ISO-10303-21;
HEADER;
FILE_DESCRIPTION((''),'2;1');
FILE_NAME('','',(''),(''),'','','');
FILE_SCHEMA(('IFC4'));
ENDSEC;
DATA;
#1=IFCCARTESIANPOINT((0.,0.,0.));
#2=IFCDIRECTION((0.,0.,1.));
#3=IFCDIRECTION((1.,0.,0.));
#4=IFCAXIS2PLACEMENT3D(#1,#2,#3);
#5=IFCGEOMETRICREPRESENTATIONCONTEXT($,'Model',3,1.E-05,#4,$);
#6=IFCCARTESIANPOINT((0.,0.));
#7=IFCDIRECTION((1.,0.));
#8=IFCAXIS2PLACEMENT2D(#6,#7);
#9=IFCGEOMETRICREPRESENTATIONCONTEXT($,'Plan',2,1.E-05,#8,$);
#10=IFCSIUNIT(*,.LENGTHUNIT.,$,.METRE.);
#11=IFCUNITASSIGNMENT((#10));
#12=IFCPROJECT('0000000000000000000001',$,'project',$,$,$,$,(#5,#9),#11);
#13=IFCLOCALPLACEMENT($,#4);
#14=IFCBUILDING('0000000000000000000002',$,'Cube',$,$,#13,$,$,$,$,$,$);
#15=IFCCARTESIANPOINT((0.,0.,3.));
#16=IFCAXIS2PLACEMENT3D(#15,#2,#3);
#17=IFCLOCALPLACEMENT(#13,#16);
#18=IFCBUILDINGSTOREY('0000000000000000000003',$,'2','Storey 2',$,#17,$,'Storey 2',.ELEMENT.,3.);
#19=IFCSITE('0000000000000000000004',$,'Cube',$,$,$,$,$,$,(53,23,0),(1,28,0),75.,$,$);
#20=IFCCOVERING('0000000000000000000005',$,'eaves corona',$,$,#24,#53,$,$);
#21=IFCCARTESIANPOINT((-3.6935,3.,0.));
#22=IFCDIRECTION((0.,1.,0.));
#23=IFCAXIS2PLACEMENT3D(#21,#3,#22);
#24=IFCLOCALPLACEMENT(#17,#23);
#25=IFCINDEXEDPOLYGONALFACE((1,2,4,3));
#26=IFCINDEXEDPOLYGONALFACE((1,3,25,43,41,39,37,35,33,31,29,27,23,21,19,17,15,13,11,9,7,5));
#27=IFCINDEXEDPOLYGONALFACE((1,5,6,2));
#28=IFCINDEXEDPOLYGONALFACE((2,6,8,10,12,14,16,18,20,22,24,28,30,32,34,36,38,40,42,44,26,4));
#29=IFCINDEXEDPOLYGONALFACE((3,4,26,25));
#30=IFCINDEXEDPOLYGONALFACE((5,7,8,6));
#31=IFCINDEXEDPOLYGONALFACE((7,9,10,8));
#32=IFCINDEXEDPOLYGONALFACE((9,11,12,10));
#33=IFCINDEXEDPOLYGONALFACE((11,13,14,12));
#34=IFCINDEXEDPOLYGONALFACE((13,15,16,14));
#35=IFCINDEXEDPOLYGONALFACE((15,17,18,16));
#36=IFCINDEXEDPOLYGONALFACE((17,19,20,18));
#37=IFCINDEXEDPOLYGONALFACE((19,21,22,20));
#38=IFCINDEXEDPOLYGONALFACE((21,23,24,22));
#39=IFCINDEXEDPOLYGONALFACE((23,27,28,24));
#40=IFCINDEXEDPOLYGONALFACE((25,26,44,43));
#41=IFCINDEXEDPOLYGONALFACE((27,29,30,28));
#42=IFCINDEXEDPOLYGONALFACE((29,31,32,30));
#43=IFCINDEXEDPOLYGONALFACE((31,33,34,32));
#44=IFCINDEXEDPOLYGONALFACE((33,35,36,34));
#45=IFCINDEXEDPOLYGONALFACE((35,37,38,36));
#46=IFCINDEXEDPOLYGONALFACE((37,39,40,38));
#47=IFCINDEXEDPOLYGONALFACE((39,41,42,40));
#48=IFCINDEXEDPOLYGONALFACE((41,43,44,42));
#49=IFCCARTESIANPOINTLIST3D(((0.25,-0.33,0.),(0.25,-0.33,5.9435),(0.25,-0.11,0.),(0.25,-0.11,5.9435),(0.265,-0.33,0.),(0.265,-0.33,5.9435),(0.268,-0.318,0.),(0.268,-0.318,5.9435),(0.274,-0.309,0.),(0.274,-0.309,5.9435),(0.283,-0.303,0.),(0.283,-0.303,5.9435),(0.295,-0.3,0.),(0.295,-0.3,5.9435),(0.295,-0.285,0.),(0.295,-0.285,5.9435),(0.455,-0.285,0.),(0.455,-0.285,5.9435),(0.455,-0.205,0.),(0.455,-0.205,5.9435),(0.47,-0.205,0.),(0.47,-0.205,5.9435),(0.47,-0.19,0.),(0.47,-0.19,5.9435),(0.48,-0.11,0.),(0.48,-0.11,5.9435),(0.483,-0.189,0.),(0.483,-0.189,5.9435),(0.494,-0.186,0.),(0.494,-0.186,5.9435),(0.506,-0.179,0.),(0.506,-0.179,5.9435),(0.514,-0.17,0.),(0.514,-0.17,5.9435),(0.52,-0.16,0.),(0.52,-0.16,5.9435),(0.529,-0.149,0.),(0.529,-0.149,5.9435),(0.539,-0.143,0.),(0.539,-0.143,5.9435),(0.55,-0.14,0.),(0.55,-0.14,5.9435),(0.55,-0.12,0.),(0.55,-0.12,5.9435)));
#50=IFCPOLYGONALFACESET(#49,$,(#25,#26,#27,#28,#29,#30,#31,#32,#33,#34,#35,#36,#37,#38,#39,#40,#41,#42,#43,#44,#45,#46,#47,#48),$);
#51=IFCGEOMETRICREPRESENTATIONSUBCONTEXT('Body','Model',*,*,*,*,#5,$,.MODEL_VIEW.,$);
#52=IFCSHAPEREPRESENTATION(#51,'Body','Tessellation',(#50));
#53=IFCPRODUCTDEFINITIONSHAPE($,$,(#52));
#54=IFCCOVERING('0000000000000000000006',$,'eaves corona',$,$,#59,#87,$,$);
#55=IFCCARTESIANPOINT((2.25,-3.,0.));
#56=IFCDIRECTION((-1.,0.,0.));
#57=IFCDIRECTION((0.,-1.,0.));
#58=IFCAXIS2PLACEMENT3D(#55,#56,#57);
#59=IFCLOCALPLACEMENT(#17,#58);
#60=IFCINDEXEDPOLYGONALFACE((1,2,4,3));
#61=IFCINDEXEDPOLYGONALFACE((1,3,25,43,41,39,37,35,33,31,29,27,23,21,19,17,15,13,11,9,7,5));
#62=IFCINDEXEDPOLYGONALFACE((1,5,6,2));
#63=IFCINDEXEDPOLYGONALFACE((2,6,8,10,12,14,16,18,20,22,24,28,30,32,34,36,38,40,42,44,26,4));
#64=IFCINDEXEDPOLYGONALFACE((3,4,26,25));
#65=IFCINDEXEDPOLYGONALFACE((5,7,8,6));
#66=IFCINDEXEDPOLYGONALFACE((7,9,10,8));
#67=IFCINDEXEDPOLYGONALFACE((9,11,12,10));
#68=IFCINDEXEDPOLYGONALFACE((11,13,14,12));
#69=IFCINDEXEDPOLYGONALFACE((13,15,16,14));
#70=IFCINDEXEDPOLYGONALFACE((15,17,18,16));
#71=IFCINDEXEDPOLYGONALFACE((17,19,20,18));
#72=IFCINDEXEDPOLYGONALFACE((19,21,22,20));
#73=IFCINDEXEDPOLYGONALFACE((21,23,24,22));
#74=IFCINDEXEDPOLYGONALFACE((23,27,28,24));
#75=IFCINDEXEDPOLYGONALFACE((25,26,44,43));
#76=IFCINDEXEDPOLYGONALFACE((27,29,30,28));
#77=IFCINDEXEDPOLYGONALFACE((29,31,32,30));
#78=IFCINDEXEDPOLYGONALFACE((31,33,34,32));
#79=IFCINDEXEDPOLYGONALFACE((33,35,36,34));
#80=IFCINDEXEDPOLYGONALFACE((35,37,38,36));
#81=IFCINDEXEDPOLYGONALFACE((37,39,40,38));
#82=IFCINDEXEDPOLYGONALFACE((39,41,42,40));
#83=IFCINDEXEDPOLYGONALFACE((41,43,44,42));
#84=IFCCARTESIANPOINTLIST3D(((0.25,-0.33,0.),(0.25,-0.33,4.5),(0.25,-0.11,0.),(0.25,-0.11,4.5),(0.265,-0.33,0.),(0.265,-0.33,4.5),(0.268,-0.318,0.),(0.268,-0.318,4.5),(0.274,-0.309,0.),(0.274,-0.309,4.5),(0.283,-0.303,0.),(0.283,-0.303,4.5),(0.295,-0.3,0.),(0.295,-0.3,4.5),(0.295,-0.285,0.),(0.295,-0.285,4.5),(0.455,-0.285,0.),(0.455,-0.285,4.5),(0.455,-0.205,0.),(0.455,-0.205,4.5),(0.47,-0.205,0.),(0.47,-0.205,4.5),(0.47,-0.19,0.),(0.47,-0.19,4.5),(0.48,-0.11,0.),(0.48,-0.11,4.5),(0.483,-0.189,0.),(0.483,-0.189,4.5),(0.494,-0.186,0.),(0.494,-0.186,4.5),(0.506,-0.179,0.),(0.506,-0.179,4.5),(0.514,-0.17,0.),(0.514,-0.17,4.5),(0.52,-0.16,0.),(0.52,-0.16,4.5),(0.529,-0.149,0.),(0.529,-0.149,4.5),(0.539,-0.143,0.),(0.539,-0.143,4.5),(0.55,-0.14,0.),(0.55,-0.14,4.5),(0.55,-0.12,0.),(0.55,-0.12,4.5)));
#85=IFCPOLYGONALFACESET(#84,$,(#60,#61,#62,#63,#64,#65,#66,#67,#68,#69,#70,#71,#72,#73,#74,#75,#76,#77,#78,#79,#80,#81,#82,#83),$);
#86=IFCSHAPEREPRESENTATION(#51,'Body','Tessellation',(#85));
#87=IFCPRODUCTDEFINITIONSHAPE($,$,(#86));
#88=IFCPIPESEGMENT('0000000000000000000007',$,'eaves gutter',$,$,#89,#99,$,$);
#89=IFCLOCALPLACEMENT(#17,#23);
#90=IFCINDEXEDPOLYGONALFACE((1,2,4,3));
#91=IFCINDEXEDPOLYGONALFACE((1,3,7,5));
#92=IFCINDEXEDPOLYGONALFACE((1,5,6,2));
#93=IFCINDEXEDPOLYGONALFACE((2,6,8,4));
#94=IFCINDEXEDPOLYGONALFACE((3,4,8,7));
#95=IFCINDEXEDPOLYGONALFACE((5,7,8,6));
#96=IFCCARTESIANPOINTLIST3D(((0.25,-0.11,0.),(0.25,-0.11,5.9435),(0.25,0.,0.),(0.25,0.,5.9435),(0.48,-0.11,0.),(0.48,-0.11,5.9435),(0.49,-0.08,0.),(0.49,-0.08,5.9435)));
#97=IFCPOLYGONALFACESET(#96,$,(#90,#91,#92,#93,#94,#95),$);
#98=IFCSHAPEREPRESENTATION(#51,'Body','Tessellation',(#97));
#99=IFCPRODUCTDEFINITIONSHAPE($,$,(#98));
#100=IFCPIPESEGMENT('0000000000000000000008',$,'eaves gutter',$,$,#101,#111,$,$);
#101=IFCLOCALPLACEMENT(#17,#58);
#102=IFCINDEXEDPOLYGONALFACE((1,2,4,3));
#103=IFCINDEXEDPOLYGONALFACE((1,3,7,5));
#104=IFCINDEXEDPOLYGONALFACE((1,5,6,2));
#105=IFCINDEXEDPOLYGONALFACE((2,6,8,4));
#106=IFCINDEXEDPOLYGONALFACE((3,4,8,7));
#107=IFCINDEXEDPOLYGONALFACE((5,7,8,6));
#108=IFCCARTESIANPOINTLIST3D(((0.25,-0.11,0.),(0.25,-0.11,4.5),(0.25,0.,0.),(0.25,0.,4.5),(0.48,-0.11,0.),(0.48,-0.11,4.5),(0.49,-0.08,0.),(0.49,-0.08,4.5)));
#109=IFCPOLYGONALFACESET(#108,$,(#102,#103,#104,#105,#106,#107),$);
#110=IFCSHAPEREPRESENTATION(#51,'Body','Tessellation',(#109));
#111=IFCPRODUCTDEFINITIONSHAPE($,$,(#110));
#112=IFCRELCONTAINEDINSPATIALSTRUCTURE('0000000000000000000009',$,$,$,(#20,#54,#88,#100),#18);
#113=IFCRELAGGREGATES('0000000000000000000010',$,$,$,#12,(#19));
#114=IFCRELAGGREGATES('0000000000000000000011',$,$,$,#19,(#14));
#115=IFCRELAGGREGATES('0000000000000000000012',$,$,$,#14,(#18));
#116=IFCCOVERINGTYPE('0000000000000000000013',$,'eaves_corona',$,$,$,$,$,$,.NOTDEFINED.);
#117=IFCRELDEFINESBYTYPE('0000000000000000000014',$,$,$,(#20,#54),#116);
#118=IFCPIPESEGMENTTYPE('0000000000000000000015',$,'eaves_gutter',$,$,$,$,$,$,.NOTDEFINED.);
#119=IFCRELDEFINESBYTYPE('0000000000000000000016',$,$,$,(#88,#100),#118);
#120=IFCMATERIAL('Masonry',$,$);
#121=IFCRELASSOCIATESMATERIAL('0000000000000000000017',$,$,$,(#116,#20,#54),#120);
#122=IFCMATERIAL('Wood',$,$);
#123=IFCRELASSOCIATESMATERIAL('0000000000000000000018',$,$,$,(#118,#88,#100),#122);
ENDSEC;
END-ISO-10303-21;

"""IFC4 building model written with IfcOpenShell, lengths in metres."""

from ifc_helpers import new_model, si_unit, frame, origin_with_axes, origin_2d_with_axis, place, context, subcontext, project, spatial, polyline, outline, extrude, material, material_profile, profile_set, profile_usage, type_object, element, save


model = new_model("IFC4")

# Units and contexts
model_context = context("Model", 3, precision=1e-05, world=origin_with_axes())
plan_context = context("Plan", 2, precision=1e-05, world=origin_2d_with_axis())
body_context = subcontext(model_context, "Body", "Model", "MODEL_VIEW")
ifc_project = project(units=[si_unit("LENGTHUNIT", "METRE")], contexts=[model_context, plan_context])

# Site, building, storey
site = spatial("IfcSite", under=ifc_project, Name="Cube", RefLatitude=(53, 23, 0), RefLongitude=(1, 28, 0), RefElevation=75.0)
building_placement = place(None, origin_with_axes())
building = spatial("IfcBuilding", under=site, at=building_placement, Name="Cube")
storey_placement = place(building_placement, frame((0.0, 0.0, 3.0), z_axis=(0.0, 0.0, 1.0), x_axis=(1.0, 0.0, 0.0)))
storey = spatial("IfcBuildingStorey", under=building, at=storey_placement, Name="2", Description="Storey 2", LongName="Storey 2", CompositionType="ELEMENT", Elevation=3.0)

# Coverings
ifc_material_1 = material(Name="Masonry")
ifc_material_profile_1 = material_profile(ifc_material_1, outline(polyline([(0.25, -0.11), (0.25, -0.33), (0.265, -0.33), (0.268, -0.318), (0.274, -0.309), (0.283, -0.303), (0.295, -0.3), (0.295, -0.285), (0.455, -0.285), (0.455, -0.205), (0.47, -0.205), (0.47, -0.19), (0.483, -0.189), (0.494, -0.186), (0.506, -0.179), (0.514, -0.17), (0.52, -0.16), (0.529, -0.149), (0.539, -0.143), (0.55, -0.14), (0.55, -0.12), (0.48, -0.11), (0.25, -0.11)])))
ifc_profile_set_1 = profile_set([ifc_material_profile_1])
ifc_profile_usage_1 = profile_usage(ifc_profile_set_1)
covering_type_1 = type_object("IfcCoveringType", Name="eaves_corona", PredefinedType="NOTDEFINED", material=ifc_profile_set_1)
covering_1_placement = place(storey_placement, frame((-3.6935, 3.0, 0.0), z_axis=(1.0, 0.0, 0.0), x_axis=(0.0, 1.0, 0.0)))
element("IfcCovering", 1, at=covering_1_placement, inside=storey, type_object=covering_type_1, material=ifc_profile_usage_1, Name="eaves corona", context=body_context, shape_type="SweptSolid", body=[
    extrude(outline(polyline([(0.25, -0.11), (0.25, -0.33), (0.265, -0.33), (0.268, -0.318), (0.274, -0.309), (0.283, -0.303), (0.295, -0.3), (0.295, -0.285), (0.455, -0.285), (0.455, -0.205), (0.47, -0.205), (0.47, -0.19), (0.483, -0.189), (0.494, -0.186), (0.506, -0.179), (0.514, -0.17), (0.52, -0.16), (0.529, -0.149), (0.539, -0.143), (0.55, -0.14), (0.55, -0.12), (0.48, -0.11), (0.25, -0.11)])), origin_with_axes(), (0.0, 0.0, 1.0), 5.9435),
])
ifc_profile_usage_2 = profile_usage(ifc_profile_set_1)
covering_2_placement = place(storey_placement, frame((2.25, -3.0, 0.0), z_axis=(-1.0, 0.0, 0.0), x_axis=(0.0, -1.0, 0.0)))
element("IfcCovering", 2, at=covering_2_placement, inside=storey, type_object=covering_type_1, material=ifc_profile_usage_2, Name="eaves corona", context=body_context, shape_type="SweptSolid", body=[
    extrude(outline(polyline([(0.25, -0.11), (0.25, -0.33), (0.265, -0.33), (0.268, -0.318), (0.274, -0.309), (0.283, -0.303), (0.295, -0.3), (0.295, -0.285), (0.455, -0.285), (0.455, -0.205), (0.47, -0.205), (0.47, -0.19), (0.483, -0.189), (0.494, -0.186), (0.506, -0.179), (0.514, -0.17), (0.52, -0.16), (0.529, -0.149), (0.539, -0.143), (0.55, -0.14), (0.55, -0.12), (0.48, -0.11), (0.25, -0.11)])), origin_with_axes(), (0.0, 0.0, 1.0), 4.5),
])

# Pipe segments
ifc_material_2 = material(Name="Wood")
ifc_material_profile_2 = material_profile(ifc_material_2, outline(polyline([(0.25, -0.11), (0.48, -0.11), (0.49, -0.08), (0.25, 0.0), (0.25, -0.11)])))
ifc_profile_set_2 = profile_set([ifc_material_profile_2])
ifc_profile_usage_3 = profile_usage(ifc_profile_set_2)
pipe_segment_type = type_object("IfcPipeSegmentType", Name="eaves_gutter", PredefinedType="NOTDEFINED", material=ifc_profile_set_2)
pipe_segment_1_placement = place(storey_placement, frame((-3.6935, 3.0, 0.0), z_axis=(1.0, 0.0, 0.0), x_axis=(0.0, 1.0, 0.0)))
element("IfcPipeSegment", 3, at=pipe_segment_1_placement, inside=storey, type_object=pipe_segment_type, material=ifc_profile_usage_3, Name="eaves gutter", context=body_context, shape_type="SweptSolid", body=[
    extrude(outline(polyline([(0.25, -0.11), (0.48, -0.11), (0.49, -0.08), (0.25, 0.0), (0.25, -0.11)])), origin_with_axes(), (0.0, 0.0, 1.0), 5.9435),
])
ifc_profile_usage_4 = profile_usage(ifc_profile_set_2)
pipe_segment_2_placement = place(storey_placement, frame((2.25, -3.0, 0.0), z_axis=(-1.0, 0.0, 0.0), x_axis=(0.0, -1.0, 0.0)))
element("IfcPipeSegment", 4, at=pipe_segment_2_placement, inside=storey, type_object=pipe_segment_type, material=ifc_profile_usage_4, Name="eaves gutter", context=body_context, shape_type="SweptSolid", body=[
    extrude(outline(polyline([(0.25, -0.11), (0.48, -0.11), (0.49, -0.08), (0.25, 0.0), (0.25, -0.11)])), origin_with_axes(), (0.0, 0.0, 1.0), 4.5),
])

save(model, "model.ifc")
